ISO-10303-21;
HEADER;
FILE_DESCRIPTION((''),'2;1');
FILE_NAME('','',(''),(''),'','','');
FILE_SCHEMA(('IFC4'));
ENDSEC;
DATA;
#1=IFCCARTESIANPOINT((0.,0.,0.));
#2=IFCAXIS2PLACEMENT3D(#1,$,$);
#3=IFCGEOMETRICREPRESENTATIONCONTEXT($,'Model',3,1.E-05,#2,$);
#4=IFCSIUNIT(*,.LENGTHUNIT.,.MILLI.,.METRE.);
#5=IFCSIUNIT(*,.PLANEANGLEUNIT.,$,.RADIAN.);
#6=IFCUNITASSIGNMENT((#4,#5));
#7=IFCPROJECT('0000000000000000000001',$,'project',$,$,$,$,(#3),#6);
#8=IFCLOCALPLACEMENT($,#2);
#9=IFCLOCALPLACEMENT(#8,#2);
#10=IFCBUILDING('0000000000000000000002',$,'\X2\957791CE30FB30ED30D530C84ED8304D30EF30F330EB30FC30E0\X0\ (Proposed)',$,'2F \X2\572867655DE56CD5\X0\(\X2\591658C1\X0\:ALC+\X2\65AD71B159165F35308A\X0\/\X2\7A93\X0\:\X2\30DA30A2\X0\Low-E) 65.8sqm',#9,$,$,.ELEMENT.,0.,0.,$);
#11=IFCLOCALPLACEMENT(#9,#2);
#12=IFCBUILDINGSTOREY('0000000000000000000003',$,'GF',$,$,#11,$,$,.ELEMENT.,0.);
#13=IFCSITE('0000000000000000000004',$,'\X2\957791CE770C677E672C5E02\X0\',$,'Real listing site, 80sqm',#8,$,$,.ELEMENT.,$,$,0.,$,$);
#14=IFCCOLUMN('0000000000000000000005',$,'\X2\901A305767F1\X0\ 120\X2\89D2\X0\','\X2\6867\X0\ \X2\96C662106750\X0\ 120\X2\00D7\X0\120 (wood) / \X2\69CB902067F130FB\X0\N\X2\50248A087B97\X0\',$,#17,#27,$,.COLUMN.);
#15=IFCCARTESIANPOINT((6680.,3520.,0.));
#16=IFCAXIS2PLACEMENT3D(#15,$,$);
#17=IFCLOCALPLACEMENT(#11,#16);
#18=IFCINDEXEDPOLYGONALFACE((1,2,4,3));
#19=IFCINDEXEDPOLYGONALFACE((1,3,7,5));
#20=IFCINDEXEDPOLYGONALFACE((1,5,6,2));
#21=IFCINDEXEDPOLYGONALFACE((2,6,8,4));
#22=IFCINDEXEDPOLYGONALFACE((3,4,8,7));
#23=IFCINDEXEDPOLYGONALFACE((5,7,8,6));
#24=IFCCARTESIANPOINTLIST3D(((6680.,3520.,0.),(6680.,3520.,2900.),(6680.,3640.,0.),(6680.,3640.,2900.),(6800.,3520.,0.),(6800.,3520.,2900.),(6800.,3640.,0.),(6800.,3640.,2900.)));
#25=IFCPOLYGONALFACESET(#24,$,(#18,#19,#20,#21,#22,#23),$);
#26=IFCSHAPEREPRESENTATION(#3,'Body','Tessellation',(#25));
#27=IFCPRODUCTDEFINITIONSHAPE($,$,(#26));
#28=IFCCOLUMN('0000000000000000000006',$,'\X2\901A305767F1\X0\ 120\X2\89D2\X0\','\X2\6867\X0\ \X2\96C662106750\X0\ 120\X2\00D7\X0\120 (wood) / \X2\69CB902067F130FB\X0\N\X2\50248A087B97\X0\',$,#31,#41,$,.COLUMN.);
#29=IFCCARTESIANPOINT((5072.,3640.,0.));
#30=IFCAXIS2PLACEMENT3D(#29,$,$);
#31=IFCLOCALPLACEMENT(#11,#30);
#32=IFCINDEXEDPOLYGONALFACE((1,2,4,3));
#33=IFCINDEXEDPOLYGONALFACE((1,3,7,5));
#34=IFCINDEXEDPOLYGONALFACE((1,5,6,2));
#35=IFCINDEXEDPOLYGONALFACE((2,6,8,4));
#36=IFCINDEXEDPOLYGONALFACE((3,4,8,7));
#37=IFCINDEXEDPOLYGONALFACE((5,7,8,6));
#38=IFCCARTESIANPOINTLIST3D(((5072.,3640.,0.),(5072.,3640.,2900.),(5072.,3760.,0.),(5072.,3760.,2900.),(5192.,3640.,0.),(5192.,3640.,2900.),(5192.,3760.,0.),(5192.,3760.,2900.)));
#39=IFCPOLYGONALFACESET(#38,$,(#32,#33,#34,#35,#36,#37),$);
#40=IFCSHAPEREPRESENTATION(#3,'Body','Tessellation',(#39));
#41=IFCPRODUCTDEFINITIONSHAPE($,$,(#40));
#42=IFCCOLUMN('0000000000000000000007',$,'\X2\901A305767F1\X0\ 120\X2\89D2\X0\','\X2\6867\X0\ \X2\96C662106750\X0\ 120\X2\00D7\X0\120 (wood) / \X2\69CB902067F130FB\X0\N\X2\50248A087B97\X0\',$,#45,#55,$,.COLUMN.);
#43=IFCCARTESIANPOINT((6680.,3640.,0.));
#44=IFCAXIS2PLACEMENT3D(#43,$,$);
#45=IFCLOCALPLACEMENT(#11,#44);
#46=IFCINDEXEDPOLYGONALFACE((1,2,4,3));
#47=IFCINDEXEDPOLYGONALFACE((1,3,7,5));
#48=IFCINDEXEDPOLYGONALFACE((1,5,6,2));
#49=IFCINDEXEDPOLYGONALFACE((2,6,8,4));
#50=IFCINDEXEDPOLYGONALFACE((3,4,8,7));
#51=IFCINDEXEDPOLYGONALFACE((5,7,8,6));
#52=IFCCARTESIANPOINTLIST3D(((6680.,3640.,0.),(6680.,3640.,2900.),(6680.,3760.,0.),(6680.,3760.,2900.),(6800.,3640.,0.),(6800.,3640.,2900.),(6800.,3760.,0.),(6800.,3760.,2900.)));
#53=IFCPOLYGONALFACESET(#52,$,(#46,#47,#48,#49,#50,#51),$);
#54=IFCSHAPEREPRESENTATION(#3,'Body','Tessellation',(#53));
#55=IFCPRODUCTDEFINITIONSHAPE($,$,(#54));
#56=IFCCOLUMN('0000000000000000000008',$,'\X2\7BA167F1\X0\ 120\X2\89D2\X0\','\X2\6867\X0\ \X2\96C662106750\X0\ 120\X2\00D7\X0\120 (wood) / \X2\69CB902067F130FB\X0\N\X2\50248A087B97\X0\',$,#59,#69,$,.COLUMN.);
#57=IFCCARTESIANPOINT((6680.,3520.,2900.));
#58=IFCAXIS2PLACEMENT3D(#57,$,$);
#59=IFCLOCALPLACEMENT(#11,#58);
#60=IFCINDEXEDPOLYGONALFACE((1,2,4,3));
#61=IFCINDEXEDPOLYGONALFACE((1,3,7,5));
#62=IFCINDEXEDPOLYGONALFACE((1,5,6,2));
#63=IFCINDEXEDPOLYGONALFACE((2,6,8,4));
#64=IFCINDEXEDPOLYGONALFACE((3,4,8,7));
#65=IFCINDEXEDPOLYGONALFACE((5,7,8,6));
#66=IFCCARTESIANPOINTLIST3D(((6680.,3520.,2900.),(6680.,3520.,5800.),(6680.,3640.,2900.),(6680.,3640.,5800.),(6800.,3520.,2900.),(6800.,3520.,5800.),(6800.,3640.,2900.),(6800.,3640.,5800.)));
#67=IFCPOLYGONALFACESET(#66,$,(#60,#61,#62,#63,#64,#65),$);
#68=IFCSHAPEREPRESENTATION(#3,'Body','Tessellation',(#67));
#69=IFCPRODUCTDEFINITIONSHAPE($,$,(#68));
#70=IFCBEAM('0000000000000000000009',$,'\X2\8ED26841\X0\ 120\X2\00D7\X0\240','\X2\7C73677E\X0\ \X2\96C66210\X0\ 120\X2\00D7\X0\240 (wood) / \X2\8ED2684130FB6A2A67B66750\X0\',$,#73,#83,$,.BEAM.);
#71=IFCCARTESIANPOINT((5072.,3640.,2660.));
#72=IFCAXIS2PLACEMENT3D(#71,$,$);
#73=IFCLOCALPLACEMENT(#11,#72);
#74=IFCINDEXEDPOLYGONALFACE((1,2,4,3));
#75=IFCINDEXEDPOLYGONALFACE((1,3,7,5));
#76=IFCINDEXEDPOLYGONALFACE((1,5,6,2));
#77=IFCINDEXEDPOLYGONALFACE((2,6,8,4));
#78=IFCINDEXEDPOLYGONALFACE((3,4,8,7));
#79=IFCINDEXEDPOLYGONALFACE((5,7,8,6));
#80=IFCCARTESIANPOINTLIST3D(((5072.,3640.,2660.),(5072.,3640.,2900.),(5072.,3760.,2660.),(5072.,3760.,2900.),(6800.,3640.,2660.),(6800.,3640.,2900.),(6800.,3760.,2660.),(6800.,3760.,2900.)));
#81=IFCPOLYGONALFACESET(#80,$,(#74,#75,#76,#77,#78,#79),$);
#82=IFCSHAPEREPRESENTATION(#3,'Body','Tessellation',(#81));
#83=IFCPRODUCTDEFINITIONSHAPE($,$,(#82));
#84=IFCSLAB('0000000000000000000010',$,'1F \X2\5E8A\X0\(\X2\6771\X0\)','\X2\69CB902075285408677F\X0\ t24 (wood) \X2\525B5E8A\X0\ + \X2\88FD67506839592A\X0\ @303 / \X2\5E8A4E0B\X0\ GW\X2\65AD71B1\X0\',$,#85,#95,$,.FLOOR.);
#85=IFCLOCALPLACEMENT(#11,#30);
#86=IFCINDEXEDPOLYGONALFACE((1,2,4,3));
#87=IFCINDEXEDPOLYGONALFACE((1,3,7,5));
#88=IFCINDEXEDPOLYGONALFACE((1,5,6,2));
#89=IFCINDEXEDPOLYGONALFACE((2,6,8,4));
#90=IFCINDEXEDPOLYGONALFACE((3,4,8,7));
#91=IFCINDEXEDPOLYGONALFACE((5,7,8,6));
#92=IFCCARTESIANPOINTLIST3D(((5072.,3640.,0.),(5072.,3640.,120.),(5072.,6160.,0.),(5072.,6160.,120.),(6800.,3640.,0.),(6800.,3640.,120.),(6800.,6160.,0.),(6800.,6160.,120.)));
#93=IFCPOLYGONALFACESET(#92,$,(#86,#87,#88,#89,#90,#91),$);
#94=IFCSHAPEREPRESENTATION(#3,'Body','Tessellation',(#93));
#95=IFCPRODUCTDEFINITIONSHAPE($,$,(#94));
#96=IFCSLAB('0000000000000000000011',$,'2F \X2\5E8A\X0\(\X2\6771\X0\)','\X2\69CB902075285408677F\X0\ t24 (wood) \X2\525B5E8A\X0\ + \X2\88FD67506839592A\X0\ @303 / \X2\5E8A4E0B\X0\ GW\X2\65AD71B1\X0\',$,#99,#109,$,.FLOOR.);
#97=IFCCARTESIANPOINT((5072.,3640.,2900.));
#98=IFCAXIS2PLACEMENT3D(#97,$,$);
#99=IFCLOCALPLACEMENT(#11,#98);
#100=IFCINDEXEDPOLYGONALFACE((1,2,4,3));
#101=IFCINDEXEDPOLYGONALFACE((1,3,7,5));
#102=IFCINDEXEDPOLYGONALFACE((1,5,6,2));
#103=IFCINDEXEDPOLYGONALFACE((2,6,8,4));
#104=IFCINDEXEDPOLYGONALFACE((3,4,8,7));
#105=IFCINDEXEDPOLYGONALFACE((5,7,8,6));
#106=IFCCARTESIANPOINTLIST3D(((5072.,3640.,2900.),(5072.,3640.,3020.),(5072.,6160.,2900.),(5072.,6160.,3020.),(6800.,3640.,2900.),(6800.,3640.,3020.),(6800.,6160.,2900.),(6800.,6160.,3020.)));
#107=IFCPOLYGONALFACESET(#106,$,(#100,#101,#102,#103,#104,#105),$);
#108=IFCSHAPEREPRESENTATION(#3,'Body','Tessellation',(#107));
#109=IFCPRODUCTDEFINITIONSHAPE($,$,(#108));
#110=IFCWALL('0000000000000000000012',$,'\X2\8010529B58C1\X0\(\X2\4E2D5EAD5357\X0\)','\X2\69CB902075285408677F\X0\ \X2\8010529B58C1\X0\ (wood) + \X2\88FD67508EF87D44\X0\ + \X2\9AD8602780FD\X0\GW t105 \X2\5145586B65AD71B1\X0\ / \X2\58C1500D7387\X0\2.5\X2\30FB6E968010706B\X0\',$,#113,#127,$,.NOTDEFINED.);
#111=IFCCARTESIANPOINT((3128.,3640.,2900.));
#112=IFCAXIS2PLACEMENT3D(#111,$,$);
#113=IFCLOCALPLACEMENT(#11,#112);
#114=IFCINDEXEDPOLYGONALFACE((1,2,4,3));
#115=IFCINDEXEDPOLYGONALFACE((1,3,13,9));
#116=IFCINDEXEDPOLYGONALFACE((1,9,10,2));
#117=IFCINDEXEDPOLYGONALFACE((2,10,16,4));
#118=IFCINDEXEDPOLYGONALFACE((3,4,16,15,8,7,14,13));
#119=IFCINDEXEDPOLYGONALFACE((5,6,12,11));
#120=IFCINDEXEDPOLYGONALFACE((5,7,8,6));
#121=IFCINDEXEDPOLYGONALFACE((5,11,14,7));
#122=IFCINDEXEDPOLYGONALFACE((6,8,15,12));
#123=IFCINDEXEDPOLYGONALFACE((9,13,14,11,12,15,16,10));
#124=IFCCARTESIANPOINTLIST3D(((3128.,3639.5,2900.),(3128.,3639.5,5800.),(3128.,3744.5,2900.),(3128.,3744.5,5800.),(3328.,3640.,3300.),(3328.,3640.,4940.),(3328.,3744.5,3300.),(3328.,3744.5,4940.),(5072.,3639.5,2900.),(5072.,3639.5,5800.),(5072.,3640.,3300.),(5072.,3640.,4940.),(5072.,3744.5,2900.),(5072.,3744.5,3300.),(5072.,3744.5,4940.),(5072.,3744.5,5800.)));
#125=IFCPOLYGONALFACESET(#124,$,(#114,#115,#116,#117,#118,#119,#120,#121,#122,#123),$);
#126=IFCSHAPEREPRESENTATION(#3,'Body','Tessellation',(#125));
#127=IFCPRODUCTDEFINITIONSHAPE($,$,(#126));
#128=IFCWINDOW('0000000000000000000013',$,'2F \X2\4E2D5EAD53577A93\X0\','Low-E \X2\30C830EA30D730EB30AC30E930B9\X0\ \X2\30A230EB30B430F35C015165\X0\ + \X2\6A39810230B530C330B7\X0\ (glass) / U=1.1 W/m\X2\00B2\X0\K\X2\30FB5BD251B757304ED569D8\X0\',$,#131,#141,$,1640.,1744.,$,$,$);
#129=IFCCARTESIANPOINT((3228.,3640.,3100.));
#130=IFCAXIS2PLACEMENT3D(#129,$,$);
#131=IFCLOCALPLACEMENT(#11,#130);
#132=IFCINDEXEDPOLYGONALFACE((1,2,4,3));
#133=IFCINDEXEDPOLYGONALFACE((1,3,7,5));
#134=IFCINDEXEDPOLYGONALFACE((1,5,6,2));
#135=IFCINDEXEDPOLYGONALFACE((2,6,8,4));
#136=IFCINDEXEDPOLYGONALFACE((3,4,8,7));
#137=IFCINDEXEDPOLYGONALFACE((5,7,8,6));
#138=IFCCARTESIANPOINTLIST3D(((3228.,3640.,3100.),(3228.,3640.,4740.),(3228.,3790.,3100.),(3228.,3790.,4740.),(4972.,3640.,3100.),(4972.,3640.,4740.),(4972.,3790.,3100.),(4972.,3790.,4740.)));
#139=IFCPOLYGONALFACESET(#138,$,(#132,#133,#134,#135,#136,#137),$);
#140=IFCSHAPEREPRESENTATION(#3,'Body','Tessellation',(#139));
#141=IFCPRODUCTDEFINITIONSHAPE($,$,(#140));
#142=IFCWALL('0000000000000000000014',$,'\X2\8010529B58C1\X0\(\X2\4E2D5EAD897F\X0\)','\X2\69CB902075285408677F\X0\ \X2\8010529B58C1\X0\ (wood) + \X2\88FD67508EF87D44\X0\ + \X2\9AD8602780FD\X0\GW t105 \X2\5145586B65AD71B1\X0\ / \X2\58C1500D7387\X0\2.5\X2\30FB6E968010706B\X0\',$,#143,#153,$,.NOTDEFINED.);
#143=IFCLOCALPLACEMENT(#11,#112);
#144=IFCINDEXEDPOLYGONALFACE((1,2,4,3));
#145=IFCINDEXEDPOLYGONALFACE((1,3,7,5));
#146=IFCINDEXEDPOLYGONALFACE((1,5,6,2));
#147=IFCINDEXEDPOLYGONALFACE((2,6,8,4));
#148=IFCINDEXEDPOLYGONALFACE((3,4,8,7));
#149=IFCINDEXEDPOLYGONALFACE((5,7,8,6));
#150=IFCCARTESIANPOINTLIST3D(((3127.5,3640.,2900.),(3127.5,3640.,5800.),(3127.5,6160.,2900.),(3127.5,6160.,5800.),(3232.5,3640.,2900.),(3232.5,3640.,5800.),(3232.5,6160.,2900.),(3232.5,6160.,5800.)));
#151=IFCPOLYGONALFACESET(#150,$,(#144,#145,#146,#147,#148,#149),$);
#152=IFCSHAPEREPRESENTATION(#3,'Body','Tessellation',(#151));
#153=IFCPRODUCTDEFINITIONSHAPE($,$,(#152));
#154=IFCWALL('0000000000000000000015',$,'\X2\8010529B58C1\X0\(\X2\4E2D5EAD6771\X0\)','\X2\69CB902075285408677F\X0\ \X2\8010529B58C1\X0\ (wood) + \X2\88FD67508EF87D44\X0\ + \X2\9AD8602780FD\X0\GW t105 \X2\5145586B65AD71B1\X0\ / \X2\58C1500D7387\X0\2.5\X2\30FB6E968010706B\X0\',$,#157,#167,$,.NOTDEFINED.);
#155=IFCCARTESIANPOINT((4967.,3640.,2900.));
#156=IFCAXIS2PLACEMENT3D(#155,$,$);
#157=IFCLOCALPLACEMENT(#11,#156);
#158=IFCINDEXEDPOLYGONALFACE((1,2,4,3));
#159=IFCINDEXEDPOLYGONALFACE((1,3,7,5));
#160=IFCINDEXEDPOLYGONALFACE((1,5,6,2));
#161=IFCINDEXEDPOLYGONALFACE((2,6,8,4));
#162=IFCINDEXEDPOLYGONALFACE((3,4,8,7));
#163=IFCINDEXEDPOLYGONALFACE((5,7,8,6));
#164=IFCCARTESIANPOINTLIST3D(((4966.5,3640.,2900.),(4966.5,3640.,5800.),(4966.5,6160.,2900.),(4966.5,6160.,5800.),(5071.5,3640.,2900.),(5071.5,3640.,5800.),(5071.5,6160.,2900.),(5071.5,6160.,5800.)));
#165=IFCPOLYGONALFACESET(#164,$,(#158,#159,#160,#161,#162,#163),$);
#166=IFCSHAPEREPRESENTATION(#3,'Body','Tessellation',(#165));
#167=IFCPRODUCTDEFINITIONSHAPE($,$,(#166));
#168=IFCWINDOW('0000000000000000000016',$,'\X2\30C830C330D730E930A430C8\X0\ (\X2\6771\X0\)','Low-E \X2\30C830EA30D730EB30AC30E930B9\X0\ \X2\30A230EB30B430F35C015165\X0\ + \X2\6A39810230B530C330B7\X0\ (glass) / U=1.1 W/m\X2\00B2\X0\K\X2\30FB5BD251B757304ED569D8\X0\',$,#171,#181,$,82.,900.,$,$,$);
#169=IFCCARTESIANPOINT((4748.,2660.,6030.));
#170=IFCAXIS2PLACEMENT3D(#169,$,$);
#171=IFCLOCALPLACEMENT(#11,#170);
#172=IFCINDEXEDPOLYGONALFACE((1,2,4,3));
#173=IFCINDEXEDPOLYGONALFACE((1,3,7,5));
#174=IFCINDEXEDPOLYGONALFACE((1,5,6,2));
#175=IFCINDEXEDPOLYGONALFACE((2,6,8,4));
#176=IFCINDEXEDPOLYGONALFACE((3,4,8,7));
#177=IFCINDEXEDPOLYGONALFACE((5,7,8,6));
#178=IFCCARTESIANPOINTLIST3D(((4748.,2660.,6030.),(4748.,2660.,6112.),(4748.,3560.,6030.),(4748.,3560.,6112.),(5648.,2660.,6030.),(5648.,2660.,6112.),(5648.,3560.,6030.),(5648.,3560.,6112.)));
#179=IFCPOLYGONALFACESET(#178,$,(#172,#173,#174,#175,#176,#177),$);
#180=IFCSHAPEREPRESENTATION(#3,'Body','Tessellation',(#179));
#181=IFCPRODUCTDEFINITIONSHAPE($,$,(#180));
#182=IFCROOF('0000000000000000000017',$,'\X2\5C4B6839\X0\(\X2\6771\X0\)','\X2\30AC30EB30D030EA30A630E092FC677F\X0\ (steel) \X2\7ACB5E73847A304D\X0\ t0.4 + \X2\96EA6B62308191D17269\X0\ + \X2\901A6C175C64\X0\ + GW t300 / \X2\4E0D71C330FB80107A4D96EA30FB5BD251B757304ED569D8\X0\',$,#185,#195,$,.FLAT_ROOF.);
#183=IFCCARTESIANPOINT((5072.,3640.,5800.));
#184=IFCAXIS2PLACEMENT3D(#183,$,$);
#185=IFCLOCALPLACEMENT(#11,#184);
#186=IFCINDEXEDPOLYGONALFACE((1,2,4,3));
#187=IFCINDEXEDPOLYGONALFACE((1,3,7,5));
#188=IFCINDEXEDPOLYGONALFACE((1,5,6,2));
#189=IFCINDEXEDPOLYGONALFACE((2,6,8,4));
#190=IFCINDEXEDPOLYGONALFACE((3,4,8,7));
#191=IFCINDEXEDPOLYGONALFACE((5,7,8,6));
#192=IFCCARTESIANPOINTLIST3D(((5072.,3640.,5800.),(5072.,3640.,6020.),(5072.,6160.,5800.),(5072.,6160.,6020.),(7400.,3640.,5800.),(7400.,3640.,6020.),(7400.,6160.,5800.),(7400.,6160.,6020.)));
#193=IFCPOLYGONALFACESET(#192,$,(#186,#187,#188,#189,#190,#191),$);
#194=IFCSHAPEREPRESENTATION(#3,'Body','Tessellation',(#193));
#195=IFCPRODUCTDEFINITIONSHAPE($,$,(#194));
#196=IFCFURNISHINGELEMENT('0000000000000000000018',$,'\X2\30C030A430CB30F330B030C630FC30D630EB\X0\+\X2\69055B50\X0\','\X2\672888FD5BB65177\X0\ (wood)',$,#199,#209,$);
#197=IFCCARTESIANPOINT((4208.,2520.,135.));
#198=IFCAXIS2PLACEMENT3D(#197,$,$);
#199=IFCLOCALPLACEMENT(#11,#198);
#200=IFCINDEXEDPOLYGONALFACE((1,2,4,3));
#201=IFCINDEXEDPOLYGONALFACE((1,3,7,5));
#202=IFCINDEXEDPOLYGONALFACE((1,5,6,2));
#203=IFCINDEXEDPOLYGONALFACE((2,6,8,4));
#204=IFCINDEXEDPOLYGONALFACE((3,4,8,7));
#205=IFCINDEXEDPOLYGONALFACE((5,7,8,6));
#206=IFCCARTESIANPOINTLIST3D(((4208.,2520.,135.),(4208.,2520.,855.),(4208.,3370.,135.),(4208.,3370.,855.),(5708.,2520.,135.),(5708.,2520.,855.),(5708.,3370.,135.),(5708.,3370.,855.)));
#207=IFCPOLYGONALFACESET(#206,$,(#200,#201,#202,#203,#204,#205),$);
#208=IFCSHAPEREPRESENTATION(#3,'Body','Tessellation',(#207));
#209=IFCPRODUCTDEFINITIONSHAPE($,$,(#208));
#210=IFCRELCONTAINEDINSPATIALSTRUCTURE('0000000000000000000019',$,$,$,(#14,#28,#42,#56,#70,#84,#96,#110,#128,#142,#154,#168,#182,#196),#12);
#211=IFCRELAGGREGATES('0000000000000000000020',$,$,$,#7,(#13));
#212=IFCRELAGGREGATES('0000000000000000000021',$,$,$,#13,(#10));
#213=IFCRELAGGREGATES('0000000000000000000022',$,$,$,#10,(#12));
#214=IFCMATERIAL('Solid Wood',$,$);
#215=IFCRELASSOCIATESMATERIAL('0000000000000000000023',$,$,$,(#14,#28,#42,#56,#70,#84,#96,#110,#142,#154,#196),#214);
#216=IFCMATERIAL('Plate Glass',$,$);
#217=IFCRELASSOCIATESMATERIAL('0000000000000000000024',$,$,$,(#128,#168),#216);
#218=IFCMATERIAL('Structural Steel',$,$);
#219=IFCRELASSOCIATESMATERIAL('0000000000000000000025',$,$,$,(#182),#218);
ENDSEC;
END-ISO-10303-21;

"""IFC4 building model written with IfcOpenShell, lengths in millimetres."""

from ifc_helpers import new_model, si_unit, frame, frame_2d, origin, place, context, project, spatial, rectangle, extrude, material, element, fill, save


model = new_model("IFC4")

# Units and contexts
model_context = context("Model", 3, precision=1e-05, world=origin())
ifc_project = project(units=[si_unit("LENGTHUNIT", "METRE", prefix="MILLI"), si_unit("PLANEANGLEUNIT", "RADIAN")], contexts=[model_context])

# Site, building, storey
site_placement = place(None, origin())
site = spatial("IfcSite", under=ifc_project, at=site_placement, Name="長野県松本市", ObjectType="Real listing site, 80sqm", CompositionType="ELEMENT", RefElevation=0.0)
building_placement = place(site_placement, origin())
building = spatial("IfcBuilding", under=site, at=building_placement, Name="長野・ロフト付きワンルーム (Proposed)", ObjectType="2F 在来工法(外壁:ALC+断熱外張り/窓:ペアLow-E) 65.8sqm", CompositionType="ELEMENT", ElevationOfRefHeight=0.0, ElevationOfTerrain=0.0)
storey_placement = place(building_placement, origin())
storey = spatial("IfcBuildingStorey", under=building, at=storey_placement, Name="GF", CompositionType="ELEMENT", Elevation=0.0)

# Columns
ifc_material_1 = material(Name="Solid Wood")
column_1_placement = place(storey_placement, frame((6680.0, 3520.0, 0.0)))
element("IfcColumn", 1, at=column_1_placement, inside=storey, material=ifc_material_1, Name="通し柱 120角", Description="桧 集成材 120×120 (wood) / 構造柱・N値計算", PredefinedType="COLUMN", context=model_context, shape_type="SweptSolid", body=[
    extrude(rectangle(XDim=120.0, YDim=120.0, at=frame_2d((60.0, 60.0))), frame((6680.0, 3520.0, 0.0)), (0.0, 0.0, 1.0), 2900.0),
])
column_2_placement = place(storey_placement, frame((5072.0, 3640.0, 0.0)))
element("IfcColumn", 2, at=column_2_placement, inside=storey, material=ifc_material_1, Name="通し柱 120角", Description="桧 集成材 120×120 (wood) / 構造柱・N値計算", PredefinedType="COLUMN", context=model_context, shape_type="SweptSolid", body=[
    extrude(rectangle(XDim=120.0, YDim=120.0, at=frame_2d((60.0, 60.0))), frame((5072.0, 3640.0, 0.0)), (0.0, 0.0, 1.0), 2900.0),
])
column_3_placement = place(storey_placement, frame((6680.0, 3640.0, 0.0)))
element("IfcColumn", 3, at=column_3_placement, inside=storey, material=ifc_material_1, Name="通し柱 120角", Description="桧 集成材 120×120 (wood) / 構造柱・N値計算", PredefinedType="COLUMN", context=model_context, shape_type="SweptSolid", body=[
    extrude(rectangle(XDim=120.0, YDim=120.0, at=frame_2d((60.0, 60.0))), frame((6680.0, 3640.0, 0.0)), (0.0, 0.0, 1.0), 2900.0),
])
column_4_placement = place(storey_placement, frame((6680.0, 3520.0, 2900.0)))
element("IfcColumn", 4, at=column_4_placement, inside=storey, material=ifc_material_1, Name="管柱 120角", Description="桧 集成材 120×120 (wood) / 構造柱・N値計算", PredefinedType="COLUMN", context=model_context, shape_type="SweptSolid", body=[
    extrude(rectangle(XDim=120.0, YDim=120.0, at=frame_2d((60.0, 60.0))), frame((6680.0, 3520.0, 2900.0)), (0.0, 0.0, 1.0), 2900.0),
])

# Beam
beam_1_placement = place(storey_placement, frame((5072.0, 3640.0, 2660.0)))
element("IfcBeam", 5, at=beam_1_placement, inside=storey, material=ifc_material_1, Name="軒桁 120×240", Description="米松 集成 120×240 (wood) / 軒桁・横架材", PredefinedType="BEAM", context=model_context, shape_type="SweptSolid", body=[
    extrude(rectangle(XDim=1728.0, YDim=120.0, at=frame_2d((864.0, 60.0))), frame((5072.0, 3640.0, 2660.0)), (0.0, 0.0, 1.0), 240.0),
])

# Slabs
slab_1_placement = place(storey_placement, frame((5072.0, 3640.0, 0.0)))
element("IfcSlab", 6, at=slab_1_placement, inside=storey, material=ifc_material_1, Name="1F 床(東)", Description="構造用合板 t24 (wood) 剛床 + 製材根太 @303 / 床下 GW断熱", PredefinedType="FLOOR", context=model_context, shape_type="SweptSolid", body=[
    extrude(rectangle(XDim=1728.0, YDim=2520.0, at=frame_2d((864.0, 1260.0))), frame((5072.0, 3640.0, 0.0)), (0.0, 0.0, 1.0), 120.0),
])
slab_2_placement = place(storey_placement, frame((5072.0, 3640.0, 2900.0)))
element("IfcSlab", 7, at=slab_2_placement, inside=storey, material=ifc_material_1, Name="2F 床(東)", Description="構造用合板 t24 (wood) 剛床 + 製材根太 @303 / 床下 GW断熱", PredefinedType="FLOOR", context=model_context, shape_type="SweptSolid", body=[
    extrude(rectangle(XDim=1728.0, YDim=2520.0, at=frame_2d((864.0, 1260.0))), frame((5072.0, 3640.0, 2900.0)), (0.0, 0.0, 1.0), 120.0),
])

# Wall, opening, window
wall_1_placement = place(storey_placement, frame((3128.0, 3640.0, 2900.0)))
wall_1 = element("IfcWall", 8, at=wall_1_placement, inside=storey, material=ifc_material_1, Name="耐力壁(中庭南)", Description="構造用合板 耐力壁 (wood) + 製材軸組 + 高性能GW t105 充填断熱 / 壁倍率2.5・準耐火", PredefinedType="NOTDEFINED", context=model_context, shape_type="SweptSolid", body=[
    extrude(rectangle(XDim=1944.0, YDim=105.0, at=frame_2d((972.0, 52.0))), frame((3128.0, 3640.0, 2900.0)), (0.0, 0.0, 1.0), 2900.0),
])
opening_placement = place(storey_placement, frame((3228.0, 3640.0, 3100.0)))
opening = element("IfcOpeningElement", 9, at=opening_placement, cuts=wall_1, PredefinedType="NOTDEFINED", context=model_context, shape_type="SweptSolid", body=[
    extrude(rectangle(XDim=1744.0, YDim=150.0, at=frame_2d((872.0, 75.0))), frame((3228.0, 3640.0, 3100.0)), (0.0, 0.0, 1.0), 1640.0),
])
ifc_material_2 = material(Name="Plate Glass")
window_1_placement = place(storey_placement, frame((3228.0, 3640.0, 3100.0)))
window_1 = element("IfcWindow", 10, at=window_1_placement, inside=storey, material=ifc_material_2, Name="2F 中庭南窓", Description="Low-E トリプルガラス アルゴン封入 + 樹脂サッシ (glass) / U=1.1 W/m²K・寒冷地仕様", OverallHeight=1640.0, OverallWidth=1744.0, context=model_context, shape_type="SweptSolid", body=[
    extrude(rectangle(XDim=1744.0, YDim=150.0, at=frame_2d((872.0, 75.0))), frame((3228.0, 3640.0, 3100.0)), (0.0, 0.0, 1.0), 1640.0),
])
fill(opening, window_1)

# Walls
wall_2_placement = place(storey_placement, frame((3128.0, 3640.0, 2900.0)))
element("IfcWall", 11, at=wall_2_placement, inside=storey, material=ifc_material_1, Name="耐力壁(中庭西)", Description="構造用合板 耐力壁 (wood) + 製材軸組 + 高性能GW t105 充填断熱 / 壁倍率2.5・準耐火", PredefinedType="NOTDEFINED", context=model_context, shape_type="SweptSolid", body=[
    extrude(rectangle(XDim=105.0, YDim=2520.0, at=frame_2d((52.0, 1260.0))), frame((3128.0, 3640.0, 2900.0)), (0.0, 0.0, 1.0), 2900.0),
])
wall_3_placement = place(storey_placement, frame((4967.0, 3640.0, 2900.0)))
element("IfcWall", 12, at=wall_3_placement, inside=storey, material=ifc_material_1, Name="耐力壁(中庭東)", Description="構造用合板 耐力壁 (wood) + 製材軸組 + 高性能GW t105 充填断熱 / 壁倍率2.5・準耐火", PredefinedType="NOTDEFINED", context=model_context, shape_type="SweptSolid", body=[
    extrude(rectangle(XDim=105.0, YDim=2520.0, at=frame_2d((52.0, 1260.0))), frame((4967.0, 3640.0, 2900.0)), (0.0, 0.0, 1.0), 2900.0),
])

# Window
window_2_placement = place(storey_placement, frame((4748.0, 2660.0, 6030.0)))
element("IfcWindow", 13, at=window_2_placement, inside=storey, material=ifc_material_2, Name="トップライト (東)", Description="Low-E トリプルガラス アルゴン封入 + 樹脂サッシ (glass) / U=1.1 W/m²K・寒冷地仕様", OverallHeight=82.0, OverallWidth=900.0, context=model_context, shape_type="SweptSolid", body=[
    extrude(rectangle(XDim=900.0, YDim=900.0, at=frame_2d((450.0, 450.0))), frame((4748.0, 2660.0, 6030.0)), (0.0, 0.0, 1.0), 82.0),
])

# Roof
ifc_material_3 = material(Name="Structural Steel")
for number, where, name in (
    (14, (5072.0, 3640.0, 5800.0), "屋根(東)"),
):
    element("IfcRoof", number, at=place(storey_placement, frame(where)), inside=storey, material=ifc_material_3, Name=name, Description="ガルバリウム鋼板 (steel) 立平葺き t0.4 + 雪止め金物 + 通気層 + GW t300 / 不燃・耐積雪・寒冷地仕様", PredefinedType="FLAT_ROOF", context=model_context, shape_type="SweptSolid", body=[
        extrude(rectangle(XDim=2328.0, YDim=2520.0, at=frame_2d((1164.0, 1260.0))), frame((5072.0, 3640.0, 5800.0)), (0.0, 0.0, 1.0), 220.0),
    ])

# Furnishing element
furnishing_1_placement = place(storey_placement, frame((4208.0, 2520.0, 135.0)))
element("IfcFurnishingElement", 15, at=furnishing_1_placement, inside=storey, material=ifc_material_1, Name="ダイニングテーブル+椅子", Description="木製家具 (wood)", context=model_context, shape_type="SweptSolid", body=[
    extrude(rectangle(XDim=1500.0, YDim=850.0, at=frame_2d((750.0, 425.0))), frame((4208.0, 2520.0, 135.0)), (0.0, 0.0, 1.0), 720.0),
])

save(model, "model.ifc")
